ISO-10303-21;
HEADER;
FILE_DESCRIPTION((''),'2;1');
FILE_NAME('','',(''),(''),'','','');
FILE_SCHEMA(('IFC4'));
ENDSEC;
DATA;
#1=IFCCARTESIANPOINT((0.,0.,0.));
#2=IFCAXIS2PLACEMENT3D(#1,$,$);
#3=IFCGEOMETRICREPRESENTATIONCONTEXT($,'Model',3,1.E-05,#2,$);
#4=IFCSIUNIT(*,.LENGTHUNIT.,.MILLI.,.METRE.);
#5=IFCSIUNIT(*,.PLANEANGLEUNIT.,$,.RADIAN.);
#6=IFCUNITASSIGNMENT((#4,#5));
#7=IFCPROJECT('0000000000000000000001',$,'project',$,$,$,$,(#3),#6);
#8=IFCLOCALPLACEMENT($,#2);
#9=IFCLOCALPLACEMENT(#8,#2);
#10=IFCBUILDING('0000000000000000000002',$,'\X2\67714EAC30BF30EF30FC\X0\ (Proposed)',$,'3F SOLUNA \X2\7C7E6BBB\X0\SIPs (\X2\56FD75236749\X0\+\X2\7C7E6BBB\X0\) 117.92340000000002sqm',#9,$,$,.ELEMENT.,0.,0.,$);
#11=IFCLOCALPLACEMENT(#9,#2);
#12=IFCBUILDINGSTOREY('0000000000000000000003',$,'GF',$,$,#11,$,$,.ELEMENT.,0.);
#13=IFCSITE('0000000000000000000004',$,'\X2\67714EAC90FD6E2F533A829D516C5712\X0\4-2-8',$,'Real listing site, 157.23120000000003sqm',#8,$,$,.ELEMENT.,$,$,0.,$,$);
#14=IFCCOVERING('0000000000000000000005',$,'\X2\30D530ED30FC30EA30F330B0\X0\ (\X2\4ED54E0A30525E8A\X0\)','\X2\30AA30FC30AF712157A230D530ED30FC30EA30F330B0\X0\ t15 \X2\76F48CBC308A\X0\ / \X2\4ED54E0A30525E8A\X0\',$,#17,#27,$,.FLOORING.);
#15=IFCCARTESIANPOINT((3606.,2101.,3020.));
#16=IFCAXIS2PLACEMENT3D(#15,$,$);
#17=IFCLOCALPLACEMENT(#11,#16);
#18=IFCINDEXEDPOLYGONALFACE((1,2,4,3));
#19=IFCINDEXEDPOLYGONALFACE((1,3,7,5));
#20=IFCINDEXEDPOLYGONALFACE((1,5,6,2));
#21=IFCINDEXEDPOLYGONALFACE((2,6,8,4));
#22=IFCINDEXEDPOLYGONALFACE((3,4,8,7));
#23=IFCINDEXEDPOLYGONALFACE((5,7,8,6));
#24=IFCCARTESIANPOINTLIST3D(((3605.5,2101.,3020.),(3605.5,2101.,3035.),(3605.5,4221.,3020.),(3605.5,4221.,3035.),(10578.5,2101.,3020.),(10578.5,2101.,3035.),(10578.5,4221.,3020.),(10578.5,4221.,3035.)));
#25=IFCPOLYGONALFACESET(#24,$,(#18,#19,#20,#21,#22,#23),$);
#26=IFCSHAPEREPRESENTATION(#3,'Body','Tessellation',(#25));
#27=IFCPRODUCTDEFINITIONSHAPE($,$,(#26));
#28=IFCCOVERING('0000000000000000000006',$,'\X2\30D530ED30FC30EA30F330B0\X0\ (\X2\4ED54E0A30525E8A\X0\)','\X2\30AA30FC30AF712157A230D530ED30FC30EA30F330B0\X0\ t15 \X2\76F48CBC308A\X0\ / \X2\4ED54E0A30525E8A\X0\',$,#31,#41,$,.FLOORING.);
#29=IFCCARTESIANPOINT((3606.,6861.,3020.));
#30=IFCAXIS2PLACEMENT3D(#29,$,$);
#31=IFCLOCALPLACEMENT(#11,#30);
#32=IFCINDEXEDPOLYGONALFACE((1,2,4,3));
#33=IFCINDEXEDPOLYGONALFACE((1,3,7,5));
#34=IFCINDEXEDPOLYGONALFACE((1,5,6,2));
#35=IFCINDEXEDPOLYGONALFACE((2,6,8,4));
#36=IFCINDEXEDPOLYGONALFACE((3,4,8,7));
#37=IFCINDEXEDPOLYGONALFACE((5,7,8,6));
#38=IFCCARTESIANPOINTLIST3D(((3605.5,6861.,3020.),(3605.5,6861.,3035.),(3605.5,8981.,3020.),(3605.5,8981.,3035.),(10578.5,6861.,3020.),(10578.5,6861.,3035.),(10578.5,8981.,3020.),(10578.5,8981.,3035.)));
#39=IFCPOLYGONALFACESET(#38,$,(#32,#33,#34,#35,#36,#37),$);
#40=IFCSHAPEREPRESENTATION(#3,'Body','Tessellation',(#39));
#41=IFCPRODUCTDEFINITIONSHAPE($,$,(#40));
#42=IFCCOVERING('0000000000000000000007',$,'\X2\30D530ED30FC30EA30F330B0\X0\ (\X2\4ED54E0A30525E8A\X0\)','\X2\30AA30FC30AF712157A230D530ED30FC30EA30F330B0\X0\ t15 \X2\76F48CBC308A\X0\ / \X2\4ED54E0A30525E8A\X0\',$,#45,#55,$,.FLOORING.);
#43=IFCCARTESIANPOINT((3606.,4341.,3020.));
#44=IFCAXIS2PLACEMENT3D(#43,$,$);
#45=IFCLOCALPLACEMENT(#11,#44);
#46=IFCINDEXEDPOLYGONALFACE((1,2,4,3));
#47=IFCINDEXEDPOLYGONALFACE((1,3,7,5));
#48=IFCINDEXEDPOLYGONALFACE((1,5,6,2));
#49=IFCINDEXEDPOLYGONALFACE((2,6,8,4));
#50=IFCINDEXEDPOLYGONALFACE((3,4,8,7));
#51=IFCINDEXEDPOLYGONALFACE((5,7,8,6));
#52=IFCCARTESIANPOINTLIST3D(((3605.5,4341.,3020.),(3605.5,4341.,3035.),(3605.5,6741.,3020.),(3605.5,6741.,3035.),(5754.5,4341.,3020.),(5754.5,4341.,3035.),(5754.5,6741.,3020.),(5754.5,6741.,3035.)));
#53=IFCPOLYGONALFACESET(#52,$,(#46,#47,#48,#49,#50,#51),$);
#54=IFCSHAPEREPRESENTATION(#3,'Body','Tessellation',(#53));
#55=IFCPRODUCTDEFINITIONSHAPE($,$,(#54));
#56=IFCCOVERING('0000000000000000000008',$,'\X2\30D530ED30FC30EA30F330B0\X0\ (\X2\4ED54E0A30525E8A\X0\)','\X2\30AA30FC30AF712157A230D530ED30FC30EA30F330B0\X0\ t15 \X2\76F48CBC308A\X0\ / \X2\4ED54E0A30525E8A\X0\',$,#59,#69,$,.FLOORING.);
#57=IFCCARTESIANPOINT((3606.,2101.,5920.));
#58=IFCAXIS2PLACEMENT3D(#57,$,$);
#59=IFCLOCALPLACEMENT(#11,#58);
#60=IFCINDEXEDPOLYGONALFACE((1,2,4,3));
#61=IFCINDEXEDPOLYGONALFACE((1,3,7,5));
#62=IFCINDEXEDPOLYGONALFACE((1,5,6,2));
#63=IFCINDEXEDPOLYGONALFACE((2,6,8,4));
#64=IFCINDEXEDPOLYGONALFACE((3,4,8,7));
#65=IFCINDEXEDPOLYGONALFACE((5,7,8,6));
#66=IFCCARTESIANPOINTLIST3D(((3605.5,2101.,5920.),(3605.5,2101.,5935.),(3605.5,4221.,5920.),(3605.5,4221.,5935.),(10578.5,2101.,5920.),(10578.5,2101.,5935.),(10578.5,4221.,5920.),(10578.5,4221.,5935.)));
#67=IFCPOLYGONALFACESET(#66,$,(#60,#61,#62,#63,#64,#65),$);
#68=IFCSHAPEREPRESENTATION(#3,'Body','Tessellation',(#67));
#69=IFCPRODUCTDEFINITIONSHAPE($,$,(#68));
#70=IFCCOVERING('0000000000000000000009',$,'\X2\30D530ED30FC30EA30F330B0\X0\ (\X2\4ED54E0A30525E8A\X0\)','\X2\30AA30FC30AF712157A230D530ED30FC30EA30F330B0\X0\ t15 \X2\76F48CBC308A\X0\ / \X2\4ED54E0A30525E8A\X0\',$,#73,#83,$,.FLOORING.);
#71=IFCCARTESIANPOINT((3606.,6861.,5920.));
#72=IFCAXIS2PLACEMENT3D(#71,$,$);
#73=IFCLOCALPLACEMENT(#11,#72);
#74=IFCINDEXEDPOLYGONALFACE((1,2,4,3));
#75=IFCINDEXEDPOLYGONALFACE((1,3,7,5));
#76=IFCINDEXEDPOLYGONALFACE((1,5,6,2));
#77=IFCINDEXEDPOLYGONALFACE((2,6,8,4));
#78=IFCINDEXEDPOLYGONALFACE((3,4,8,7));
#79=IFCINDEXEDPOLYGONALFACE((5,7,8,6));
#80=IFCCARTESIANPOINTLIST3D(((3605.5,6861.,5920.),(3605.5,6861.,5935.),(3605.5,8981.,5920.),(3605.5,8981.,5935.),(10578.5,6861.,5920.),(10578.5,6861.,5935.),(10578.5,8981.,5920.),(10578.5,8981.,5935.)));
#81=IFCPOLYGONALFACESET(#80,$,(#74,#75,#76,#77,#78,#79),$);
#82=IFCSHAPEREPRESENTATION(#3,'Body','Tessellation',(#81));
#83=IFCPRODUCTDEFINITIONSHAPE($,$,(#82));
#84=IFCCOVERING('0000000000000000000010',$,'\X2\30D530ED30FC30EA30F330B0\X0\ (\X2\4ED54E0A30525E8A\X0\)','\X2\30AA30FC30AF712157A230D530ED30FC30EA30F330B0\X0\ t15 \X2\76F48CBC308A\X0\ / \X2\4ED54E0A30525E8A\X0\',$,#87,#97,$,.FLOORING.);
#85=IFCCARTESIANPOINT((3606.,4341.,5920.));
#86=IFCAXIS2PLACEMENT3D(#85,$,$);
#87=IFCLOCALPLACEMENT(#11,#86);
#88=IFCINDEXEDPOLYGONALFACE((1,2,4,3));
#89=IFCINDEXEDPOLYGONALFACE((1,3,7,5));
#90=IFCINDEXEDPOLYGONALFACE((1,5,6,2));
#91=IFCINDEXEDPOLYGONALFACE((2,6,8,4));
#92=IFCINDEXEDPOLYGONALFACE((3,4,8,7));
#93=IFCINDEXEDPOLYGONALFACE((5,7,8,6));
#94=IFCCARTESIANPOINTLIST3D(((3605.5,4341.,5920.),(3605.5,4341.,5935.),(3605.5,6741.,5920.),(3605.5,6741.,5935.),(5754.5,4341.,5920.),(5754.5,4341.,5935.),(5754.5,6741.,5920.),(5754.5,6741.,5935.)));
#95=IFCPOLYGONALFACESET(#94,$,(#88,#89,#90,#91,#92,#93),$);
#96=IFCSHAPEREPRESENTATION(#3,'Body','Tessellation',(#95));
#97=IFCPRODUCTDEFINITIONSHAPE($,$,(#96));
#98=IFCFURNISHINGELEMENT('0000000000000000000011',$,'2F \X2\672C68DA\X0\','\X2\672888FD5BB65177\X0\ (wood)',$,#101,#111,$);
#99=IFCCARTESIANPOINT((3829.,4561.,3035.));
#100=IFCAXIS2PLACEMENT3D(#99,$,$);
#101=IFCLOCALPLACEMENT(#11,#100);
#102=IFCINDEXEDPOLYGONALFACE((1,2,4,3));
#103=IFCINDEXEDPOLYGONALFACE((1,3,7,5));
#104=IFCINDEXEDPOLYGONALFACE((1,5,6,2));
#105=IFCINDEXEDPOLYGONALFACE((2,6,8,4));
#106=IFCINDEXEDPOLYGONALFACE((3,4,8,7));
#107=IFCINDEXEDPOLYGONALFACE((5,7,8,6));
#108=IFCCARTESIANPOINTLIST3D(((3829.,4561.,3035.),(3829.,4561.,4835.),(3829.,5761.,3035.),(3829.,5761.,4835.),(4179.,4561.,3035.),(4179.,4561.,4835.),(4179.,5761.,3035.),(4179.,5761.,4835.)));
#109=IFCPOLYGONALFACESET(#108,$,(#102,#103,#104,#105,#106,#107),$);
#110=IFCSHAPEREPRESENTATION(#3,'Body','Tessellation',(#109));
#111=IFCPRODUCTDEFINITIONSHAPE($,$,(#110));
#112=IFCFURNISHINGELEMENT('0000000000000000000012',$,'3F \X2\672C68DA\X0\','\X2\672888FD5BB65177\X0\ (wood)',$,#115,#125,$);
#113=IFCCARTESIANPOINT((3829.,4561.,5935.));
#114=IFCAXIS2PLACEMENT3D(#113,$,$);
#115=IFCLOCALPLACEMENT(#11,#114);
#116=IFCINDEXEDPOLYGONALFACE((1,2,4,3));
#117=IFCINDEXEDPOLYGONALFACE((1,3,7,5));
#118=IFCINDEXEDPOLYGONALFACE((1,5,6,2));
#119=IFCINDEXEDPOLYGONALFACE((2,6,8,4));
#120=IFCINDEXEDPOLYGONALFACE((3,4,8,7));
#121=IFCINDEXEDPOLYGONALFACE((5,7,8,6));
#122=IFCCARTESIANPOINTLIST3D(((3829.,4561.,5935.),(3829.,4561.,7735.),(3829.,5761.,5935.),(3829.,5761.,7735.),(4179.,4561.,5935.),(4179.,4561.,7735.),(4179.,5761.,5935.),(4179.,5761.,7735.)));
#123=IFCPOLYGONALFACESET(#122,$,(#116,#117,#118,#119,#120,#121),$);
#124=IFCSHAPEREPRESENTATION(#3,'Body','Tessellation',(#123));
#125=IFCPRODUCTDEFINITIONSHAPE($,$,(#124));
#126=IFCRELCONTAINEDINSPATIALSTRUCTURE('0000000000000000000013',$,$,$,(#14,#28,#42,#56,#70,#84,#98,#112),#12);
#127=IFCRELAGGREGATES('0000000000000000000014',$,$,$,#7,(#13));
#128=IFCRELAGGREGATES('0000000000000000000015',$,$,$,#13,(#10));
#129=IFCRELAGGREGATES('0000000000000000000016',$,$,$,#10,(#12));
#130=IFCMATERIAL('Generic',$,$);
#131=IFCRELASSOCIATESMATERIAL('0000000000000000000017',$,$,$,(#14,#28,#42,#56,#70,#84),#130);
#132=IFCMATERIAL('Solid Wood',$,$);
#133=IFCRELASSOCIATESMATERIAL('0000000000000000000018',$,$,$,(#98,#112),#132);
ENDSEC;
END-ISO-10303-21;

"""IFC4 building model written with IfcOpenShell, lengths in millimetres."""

from ifc_helpers import new_model, si_unit, frame, frame_2d, origin, place, context, project, spatial, rectangle, extrude, material, element, save


model = new_model("IFC4")

# Units and contexts
model_context = context("Model", 3, precision=1e-05, world=origin())
ifc_project = project(units=[si_unit("LENGTHUNIT", "METRE", prefix="MILLI"), si_unit("PLANEANGLEUNIT", "RADIAN")], contexts=[model_context])

# Site, building, storey
site_placement = place(None, origin())
site = spatial("IfcSite", under=ifc_project, at=site_placement, Name="東京都港区芝公園4-2-8", ObjectType="Real listing site, 157.23120000000003sqm", CompositionType="ELEMENT", RefElevation=0.0)
building_placement = place(site_placement, origin())
building = spatial("IfcBuilding", under=site, at=building_placement, Name="東京タワー (Proposed)", ObjectType="3F SOLUNA 籾殻SIPs (国産杉+籾殻) 117.92340000000002sqm", CompositionType="ELEMENT", ElevationOfRefHeight=0.0, ElevationOfTerrain=0.0)
storey_placement = place(building_placement, origin())
storey = spatial("IfcBuildingStorey", under=building, at=storey_placement, Name="GF", CompositionType="ELEMENT", Elevation=0.0)

# Shared definitions
ifc_material_1 = material(Name="Solid Wood")

# Coverings
ifc_material_2 = material(Name="Generic")
covering_1_placement = place(storey_placement, frame((3606.0, 2101.0, 3020.0)))
element("IfcCovering", 1, at=covering_1_placement, inside=storey, material=ifc_material_2, Name="フローリング (仕上げ床)", Description="オーク無垢フローリング t15 直貼り / 仕上げ床", PredefinedType="FLOORING", context=model_context, shape_type="SweptSolid", body=[
    extrude(rectangle(XDim=6973.0, YDim=2120.0, at=frame_2d((3486.0, 1060.0))), frame((3606.0, 2101.0, 3020.0)), (0.0, 0.0, 1.0), 15.0),
])
covering_2_placement = place(storey_placement, frame((3606.0, 6861.0, 3020.0)))
element("IfcCovering", 2, at=covering_2_placement, inside=storey, material=ifc_material_2, Name="フローリング (仕上げ床)", Description="オーク無垢フローリング t15 直貼り / 仕上げ床", PredefinedType="FLOORING", context=model_context, shape_type="SweptSolid", body=[
    extrude(rectangle(XDim=6973.0, YDim=2120.0, at=frame_2d((3486.0, 1060.0))), frame((3606.0, 6861.0, 3020.0)), (0.0, 0.0, 1.0), 15.0),
])
covering_3_placement = place(storey_placement, frame((3606.0, 4341.0, 3020.0)))
element("IfcCovering", 3, at=covering_3_placement, inside=storey, material=ifc_material_2, Name="フローリング (仕上げ床)", Description="オーク無垢フローリング t15 直貼り / 仕上げ床", PredefinedType="FLOORING", context=model_context, shape_type="SweptSolid", body=[
    extrude(rectangle(XDim=2149.0, YDim=2400.0, at=frame_2d((1074.0, 1200.0))), frame((3606.0, 4341.0, 3020.0)), (0.0, 0.0, 1.0), 15.0),
])
covering_4_placement = place(storey_placement, frame((3606.0, 2101.0, 5920.0)))
element("IfcCovering", 4, at=covering_4_placement, inside=storey, material=ifc_material_2, Name="フローリング (仕上げ床)", Description="オーク無垢フローリング t15 直貼り / 仕上げ床", PredefinedType="FLOORING", context=model_context, shape_type="SweptSolid", body=[
    extrude(rectangle(XDim=6973.0, YDim=2120.0, at=frame_2d((3486.0, 1060.0))), frame((3606.0, 2101.0, 5920.0)), (0.0, 0.0, 1.0), 15.0),
])
covering_5_placement = place(storey_placement, frame((3606.0, 6861.0, 5920.0)))
element("IfcCovering", 5, at=covering_5_placement, inside=storey, material=ifc_material_2, Name="フローリング (仕上げ床)", Description="オーク無垢フローリング t15 直貼り / 仕上げ床", PredefinedType="FLOORING", context=model_context, shape_type="SweptSolid", body=[
    extrude(rectangle(XDim=6973.0, YDim=2120.0, at=frame_2d((3486.0, 1060.0))), frame((3606.0, 6861.0, 5920.0)), (0.0, 0.0, 1.0), 15.0),
])
covering_6_placement = place(storey_placement, frame((3606.0, 4341.0, 5920.0)))
element("IfcCovering", 6, at=covering_6_placement, inside=storey, material=ifc_material_2, Name="フローリング (仕上げ床)", Description="オーク無垢フローリング t15 直貼り / 仕上げ床", PredefinedType="FLOORING", context=model_context, shape_type="SweptSolid", body=[
    extrude(rectangle(XDim=2149.0, YDim=2400.0, at=frame_2d((1074.0, 1200.0))), frame((3606.0, 4341.0, 5920.0)), (0.0, 0.0, 1.0), 15.0),
])

# Furnishing elements
furnishing_1_placement = place(storey_placement, frame((3829.0, 4561.0, 3035.0)))
element("IfcFurnishingElement", 7, at=furnishing_1_placement, inside=storey, material=ifc_material_1, Name="2F 本棚", Description="木製家具 (wood)", context=model_context, shape_type="SweptSolid", body=[
    extrude(rectangle(XDim=350.0, YDim=1200.0, at=frame_2d((175.0, 600.0))), frame((3829.0, 4561.0, 3035.0)), (0.0, 0.0, 1.0), 1800.0),
])
furnishing_2_placement = place(storey_placement, frame((3829.0, 4561.0, 5935.0)))
element("IfcFurnishingElement", 8, at=furnishing_2_placement, inside=storey, material=ifc_material_1, Name="3F 本棚", Description="木製家具 (wood)", context=model_context, shape_type="SweptSolid", body=[
    extrude(rectangle(XDim=350.0, YDim=1200.0, at=frame_2d((175.0, 600.0))), frame((3829.0, 4561.0, 5935.0)), (0.0, 0.0, 1.0), 1800.0),
])

save(model, "model.ifc")
